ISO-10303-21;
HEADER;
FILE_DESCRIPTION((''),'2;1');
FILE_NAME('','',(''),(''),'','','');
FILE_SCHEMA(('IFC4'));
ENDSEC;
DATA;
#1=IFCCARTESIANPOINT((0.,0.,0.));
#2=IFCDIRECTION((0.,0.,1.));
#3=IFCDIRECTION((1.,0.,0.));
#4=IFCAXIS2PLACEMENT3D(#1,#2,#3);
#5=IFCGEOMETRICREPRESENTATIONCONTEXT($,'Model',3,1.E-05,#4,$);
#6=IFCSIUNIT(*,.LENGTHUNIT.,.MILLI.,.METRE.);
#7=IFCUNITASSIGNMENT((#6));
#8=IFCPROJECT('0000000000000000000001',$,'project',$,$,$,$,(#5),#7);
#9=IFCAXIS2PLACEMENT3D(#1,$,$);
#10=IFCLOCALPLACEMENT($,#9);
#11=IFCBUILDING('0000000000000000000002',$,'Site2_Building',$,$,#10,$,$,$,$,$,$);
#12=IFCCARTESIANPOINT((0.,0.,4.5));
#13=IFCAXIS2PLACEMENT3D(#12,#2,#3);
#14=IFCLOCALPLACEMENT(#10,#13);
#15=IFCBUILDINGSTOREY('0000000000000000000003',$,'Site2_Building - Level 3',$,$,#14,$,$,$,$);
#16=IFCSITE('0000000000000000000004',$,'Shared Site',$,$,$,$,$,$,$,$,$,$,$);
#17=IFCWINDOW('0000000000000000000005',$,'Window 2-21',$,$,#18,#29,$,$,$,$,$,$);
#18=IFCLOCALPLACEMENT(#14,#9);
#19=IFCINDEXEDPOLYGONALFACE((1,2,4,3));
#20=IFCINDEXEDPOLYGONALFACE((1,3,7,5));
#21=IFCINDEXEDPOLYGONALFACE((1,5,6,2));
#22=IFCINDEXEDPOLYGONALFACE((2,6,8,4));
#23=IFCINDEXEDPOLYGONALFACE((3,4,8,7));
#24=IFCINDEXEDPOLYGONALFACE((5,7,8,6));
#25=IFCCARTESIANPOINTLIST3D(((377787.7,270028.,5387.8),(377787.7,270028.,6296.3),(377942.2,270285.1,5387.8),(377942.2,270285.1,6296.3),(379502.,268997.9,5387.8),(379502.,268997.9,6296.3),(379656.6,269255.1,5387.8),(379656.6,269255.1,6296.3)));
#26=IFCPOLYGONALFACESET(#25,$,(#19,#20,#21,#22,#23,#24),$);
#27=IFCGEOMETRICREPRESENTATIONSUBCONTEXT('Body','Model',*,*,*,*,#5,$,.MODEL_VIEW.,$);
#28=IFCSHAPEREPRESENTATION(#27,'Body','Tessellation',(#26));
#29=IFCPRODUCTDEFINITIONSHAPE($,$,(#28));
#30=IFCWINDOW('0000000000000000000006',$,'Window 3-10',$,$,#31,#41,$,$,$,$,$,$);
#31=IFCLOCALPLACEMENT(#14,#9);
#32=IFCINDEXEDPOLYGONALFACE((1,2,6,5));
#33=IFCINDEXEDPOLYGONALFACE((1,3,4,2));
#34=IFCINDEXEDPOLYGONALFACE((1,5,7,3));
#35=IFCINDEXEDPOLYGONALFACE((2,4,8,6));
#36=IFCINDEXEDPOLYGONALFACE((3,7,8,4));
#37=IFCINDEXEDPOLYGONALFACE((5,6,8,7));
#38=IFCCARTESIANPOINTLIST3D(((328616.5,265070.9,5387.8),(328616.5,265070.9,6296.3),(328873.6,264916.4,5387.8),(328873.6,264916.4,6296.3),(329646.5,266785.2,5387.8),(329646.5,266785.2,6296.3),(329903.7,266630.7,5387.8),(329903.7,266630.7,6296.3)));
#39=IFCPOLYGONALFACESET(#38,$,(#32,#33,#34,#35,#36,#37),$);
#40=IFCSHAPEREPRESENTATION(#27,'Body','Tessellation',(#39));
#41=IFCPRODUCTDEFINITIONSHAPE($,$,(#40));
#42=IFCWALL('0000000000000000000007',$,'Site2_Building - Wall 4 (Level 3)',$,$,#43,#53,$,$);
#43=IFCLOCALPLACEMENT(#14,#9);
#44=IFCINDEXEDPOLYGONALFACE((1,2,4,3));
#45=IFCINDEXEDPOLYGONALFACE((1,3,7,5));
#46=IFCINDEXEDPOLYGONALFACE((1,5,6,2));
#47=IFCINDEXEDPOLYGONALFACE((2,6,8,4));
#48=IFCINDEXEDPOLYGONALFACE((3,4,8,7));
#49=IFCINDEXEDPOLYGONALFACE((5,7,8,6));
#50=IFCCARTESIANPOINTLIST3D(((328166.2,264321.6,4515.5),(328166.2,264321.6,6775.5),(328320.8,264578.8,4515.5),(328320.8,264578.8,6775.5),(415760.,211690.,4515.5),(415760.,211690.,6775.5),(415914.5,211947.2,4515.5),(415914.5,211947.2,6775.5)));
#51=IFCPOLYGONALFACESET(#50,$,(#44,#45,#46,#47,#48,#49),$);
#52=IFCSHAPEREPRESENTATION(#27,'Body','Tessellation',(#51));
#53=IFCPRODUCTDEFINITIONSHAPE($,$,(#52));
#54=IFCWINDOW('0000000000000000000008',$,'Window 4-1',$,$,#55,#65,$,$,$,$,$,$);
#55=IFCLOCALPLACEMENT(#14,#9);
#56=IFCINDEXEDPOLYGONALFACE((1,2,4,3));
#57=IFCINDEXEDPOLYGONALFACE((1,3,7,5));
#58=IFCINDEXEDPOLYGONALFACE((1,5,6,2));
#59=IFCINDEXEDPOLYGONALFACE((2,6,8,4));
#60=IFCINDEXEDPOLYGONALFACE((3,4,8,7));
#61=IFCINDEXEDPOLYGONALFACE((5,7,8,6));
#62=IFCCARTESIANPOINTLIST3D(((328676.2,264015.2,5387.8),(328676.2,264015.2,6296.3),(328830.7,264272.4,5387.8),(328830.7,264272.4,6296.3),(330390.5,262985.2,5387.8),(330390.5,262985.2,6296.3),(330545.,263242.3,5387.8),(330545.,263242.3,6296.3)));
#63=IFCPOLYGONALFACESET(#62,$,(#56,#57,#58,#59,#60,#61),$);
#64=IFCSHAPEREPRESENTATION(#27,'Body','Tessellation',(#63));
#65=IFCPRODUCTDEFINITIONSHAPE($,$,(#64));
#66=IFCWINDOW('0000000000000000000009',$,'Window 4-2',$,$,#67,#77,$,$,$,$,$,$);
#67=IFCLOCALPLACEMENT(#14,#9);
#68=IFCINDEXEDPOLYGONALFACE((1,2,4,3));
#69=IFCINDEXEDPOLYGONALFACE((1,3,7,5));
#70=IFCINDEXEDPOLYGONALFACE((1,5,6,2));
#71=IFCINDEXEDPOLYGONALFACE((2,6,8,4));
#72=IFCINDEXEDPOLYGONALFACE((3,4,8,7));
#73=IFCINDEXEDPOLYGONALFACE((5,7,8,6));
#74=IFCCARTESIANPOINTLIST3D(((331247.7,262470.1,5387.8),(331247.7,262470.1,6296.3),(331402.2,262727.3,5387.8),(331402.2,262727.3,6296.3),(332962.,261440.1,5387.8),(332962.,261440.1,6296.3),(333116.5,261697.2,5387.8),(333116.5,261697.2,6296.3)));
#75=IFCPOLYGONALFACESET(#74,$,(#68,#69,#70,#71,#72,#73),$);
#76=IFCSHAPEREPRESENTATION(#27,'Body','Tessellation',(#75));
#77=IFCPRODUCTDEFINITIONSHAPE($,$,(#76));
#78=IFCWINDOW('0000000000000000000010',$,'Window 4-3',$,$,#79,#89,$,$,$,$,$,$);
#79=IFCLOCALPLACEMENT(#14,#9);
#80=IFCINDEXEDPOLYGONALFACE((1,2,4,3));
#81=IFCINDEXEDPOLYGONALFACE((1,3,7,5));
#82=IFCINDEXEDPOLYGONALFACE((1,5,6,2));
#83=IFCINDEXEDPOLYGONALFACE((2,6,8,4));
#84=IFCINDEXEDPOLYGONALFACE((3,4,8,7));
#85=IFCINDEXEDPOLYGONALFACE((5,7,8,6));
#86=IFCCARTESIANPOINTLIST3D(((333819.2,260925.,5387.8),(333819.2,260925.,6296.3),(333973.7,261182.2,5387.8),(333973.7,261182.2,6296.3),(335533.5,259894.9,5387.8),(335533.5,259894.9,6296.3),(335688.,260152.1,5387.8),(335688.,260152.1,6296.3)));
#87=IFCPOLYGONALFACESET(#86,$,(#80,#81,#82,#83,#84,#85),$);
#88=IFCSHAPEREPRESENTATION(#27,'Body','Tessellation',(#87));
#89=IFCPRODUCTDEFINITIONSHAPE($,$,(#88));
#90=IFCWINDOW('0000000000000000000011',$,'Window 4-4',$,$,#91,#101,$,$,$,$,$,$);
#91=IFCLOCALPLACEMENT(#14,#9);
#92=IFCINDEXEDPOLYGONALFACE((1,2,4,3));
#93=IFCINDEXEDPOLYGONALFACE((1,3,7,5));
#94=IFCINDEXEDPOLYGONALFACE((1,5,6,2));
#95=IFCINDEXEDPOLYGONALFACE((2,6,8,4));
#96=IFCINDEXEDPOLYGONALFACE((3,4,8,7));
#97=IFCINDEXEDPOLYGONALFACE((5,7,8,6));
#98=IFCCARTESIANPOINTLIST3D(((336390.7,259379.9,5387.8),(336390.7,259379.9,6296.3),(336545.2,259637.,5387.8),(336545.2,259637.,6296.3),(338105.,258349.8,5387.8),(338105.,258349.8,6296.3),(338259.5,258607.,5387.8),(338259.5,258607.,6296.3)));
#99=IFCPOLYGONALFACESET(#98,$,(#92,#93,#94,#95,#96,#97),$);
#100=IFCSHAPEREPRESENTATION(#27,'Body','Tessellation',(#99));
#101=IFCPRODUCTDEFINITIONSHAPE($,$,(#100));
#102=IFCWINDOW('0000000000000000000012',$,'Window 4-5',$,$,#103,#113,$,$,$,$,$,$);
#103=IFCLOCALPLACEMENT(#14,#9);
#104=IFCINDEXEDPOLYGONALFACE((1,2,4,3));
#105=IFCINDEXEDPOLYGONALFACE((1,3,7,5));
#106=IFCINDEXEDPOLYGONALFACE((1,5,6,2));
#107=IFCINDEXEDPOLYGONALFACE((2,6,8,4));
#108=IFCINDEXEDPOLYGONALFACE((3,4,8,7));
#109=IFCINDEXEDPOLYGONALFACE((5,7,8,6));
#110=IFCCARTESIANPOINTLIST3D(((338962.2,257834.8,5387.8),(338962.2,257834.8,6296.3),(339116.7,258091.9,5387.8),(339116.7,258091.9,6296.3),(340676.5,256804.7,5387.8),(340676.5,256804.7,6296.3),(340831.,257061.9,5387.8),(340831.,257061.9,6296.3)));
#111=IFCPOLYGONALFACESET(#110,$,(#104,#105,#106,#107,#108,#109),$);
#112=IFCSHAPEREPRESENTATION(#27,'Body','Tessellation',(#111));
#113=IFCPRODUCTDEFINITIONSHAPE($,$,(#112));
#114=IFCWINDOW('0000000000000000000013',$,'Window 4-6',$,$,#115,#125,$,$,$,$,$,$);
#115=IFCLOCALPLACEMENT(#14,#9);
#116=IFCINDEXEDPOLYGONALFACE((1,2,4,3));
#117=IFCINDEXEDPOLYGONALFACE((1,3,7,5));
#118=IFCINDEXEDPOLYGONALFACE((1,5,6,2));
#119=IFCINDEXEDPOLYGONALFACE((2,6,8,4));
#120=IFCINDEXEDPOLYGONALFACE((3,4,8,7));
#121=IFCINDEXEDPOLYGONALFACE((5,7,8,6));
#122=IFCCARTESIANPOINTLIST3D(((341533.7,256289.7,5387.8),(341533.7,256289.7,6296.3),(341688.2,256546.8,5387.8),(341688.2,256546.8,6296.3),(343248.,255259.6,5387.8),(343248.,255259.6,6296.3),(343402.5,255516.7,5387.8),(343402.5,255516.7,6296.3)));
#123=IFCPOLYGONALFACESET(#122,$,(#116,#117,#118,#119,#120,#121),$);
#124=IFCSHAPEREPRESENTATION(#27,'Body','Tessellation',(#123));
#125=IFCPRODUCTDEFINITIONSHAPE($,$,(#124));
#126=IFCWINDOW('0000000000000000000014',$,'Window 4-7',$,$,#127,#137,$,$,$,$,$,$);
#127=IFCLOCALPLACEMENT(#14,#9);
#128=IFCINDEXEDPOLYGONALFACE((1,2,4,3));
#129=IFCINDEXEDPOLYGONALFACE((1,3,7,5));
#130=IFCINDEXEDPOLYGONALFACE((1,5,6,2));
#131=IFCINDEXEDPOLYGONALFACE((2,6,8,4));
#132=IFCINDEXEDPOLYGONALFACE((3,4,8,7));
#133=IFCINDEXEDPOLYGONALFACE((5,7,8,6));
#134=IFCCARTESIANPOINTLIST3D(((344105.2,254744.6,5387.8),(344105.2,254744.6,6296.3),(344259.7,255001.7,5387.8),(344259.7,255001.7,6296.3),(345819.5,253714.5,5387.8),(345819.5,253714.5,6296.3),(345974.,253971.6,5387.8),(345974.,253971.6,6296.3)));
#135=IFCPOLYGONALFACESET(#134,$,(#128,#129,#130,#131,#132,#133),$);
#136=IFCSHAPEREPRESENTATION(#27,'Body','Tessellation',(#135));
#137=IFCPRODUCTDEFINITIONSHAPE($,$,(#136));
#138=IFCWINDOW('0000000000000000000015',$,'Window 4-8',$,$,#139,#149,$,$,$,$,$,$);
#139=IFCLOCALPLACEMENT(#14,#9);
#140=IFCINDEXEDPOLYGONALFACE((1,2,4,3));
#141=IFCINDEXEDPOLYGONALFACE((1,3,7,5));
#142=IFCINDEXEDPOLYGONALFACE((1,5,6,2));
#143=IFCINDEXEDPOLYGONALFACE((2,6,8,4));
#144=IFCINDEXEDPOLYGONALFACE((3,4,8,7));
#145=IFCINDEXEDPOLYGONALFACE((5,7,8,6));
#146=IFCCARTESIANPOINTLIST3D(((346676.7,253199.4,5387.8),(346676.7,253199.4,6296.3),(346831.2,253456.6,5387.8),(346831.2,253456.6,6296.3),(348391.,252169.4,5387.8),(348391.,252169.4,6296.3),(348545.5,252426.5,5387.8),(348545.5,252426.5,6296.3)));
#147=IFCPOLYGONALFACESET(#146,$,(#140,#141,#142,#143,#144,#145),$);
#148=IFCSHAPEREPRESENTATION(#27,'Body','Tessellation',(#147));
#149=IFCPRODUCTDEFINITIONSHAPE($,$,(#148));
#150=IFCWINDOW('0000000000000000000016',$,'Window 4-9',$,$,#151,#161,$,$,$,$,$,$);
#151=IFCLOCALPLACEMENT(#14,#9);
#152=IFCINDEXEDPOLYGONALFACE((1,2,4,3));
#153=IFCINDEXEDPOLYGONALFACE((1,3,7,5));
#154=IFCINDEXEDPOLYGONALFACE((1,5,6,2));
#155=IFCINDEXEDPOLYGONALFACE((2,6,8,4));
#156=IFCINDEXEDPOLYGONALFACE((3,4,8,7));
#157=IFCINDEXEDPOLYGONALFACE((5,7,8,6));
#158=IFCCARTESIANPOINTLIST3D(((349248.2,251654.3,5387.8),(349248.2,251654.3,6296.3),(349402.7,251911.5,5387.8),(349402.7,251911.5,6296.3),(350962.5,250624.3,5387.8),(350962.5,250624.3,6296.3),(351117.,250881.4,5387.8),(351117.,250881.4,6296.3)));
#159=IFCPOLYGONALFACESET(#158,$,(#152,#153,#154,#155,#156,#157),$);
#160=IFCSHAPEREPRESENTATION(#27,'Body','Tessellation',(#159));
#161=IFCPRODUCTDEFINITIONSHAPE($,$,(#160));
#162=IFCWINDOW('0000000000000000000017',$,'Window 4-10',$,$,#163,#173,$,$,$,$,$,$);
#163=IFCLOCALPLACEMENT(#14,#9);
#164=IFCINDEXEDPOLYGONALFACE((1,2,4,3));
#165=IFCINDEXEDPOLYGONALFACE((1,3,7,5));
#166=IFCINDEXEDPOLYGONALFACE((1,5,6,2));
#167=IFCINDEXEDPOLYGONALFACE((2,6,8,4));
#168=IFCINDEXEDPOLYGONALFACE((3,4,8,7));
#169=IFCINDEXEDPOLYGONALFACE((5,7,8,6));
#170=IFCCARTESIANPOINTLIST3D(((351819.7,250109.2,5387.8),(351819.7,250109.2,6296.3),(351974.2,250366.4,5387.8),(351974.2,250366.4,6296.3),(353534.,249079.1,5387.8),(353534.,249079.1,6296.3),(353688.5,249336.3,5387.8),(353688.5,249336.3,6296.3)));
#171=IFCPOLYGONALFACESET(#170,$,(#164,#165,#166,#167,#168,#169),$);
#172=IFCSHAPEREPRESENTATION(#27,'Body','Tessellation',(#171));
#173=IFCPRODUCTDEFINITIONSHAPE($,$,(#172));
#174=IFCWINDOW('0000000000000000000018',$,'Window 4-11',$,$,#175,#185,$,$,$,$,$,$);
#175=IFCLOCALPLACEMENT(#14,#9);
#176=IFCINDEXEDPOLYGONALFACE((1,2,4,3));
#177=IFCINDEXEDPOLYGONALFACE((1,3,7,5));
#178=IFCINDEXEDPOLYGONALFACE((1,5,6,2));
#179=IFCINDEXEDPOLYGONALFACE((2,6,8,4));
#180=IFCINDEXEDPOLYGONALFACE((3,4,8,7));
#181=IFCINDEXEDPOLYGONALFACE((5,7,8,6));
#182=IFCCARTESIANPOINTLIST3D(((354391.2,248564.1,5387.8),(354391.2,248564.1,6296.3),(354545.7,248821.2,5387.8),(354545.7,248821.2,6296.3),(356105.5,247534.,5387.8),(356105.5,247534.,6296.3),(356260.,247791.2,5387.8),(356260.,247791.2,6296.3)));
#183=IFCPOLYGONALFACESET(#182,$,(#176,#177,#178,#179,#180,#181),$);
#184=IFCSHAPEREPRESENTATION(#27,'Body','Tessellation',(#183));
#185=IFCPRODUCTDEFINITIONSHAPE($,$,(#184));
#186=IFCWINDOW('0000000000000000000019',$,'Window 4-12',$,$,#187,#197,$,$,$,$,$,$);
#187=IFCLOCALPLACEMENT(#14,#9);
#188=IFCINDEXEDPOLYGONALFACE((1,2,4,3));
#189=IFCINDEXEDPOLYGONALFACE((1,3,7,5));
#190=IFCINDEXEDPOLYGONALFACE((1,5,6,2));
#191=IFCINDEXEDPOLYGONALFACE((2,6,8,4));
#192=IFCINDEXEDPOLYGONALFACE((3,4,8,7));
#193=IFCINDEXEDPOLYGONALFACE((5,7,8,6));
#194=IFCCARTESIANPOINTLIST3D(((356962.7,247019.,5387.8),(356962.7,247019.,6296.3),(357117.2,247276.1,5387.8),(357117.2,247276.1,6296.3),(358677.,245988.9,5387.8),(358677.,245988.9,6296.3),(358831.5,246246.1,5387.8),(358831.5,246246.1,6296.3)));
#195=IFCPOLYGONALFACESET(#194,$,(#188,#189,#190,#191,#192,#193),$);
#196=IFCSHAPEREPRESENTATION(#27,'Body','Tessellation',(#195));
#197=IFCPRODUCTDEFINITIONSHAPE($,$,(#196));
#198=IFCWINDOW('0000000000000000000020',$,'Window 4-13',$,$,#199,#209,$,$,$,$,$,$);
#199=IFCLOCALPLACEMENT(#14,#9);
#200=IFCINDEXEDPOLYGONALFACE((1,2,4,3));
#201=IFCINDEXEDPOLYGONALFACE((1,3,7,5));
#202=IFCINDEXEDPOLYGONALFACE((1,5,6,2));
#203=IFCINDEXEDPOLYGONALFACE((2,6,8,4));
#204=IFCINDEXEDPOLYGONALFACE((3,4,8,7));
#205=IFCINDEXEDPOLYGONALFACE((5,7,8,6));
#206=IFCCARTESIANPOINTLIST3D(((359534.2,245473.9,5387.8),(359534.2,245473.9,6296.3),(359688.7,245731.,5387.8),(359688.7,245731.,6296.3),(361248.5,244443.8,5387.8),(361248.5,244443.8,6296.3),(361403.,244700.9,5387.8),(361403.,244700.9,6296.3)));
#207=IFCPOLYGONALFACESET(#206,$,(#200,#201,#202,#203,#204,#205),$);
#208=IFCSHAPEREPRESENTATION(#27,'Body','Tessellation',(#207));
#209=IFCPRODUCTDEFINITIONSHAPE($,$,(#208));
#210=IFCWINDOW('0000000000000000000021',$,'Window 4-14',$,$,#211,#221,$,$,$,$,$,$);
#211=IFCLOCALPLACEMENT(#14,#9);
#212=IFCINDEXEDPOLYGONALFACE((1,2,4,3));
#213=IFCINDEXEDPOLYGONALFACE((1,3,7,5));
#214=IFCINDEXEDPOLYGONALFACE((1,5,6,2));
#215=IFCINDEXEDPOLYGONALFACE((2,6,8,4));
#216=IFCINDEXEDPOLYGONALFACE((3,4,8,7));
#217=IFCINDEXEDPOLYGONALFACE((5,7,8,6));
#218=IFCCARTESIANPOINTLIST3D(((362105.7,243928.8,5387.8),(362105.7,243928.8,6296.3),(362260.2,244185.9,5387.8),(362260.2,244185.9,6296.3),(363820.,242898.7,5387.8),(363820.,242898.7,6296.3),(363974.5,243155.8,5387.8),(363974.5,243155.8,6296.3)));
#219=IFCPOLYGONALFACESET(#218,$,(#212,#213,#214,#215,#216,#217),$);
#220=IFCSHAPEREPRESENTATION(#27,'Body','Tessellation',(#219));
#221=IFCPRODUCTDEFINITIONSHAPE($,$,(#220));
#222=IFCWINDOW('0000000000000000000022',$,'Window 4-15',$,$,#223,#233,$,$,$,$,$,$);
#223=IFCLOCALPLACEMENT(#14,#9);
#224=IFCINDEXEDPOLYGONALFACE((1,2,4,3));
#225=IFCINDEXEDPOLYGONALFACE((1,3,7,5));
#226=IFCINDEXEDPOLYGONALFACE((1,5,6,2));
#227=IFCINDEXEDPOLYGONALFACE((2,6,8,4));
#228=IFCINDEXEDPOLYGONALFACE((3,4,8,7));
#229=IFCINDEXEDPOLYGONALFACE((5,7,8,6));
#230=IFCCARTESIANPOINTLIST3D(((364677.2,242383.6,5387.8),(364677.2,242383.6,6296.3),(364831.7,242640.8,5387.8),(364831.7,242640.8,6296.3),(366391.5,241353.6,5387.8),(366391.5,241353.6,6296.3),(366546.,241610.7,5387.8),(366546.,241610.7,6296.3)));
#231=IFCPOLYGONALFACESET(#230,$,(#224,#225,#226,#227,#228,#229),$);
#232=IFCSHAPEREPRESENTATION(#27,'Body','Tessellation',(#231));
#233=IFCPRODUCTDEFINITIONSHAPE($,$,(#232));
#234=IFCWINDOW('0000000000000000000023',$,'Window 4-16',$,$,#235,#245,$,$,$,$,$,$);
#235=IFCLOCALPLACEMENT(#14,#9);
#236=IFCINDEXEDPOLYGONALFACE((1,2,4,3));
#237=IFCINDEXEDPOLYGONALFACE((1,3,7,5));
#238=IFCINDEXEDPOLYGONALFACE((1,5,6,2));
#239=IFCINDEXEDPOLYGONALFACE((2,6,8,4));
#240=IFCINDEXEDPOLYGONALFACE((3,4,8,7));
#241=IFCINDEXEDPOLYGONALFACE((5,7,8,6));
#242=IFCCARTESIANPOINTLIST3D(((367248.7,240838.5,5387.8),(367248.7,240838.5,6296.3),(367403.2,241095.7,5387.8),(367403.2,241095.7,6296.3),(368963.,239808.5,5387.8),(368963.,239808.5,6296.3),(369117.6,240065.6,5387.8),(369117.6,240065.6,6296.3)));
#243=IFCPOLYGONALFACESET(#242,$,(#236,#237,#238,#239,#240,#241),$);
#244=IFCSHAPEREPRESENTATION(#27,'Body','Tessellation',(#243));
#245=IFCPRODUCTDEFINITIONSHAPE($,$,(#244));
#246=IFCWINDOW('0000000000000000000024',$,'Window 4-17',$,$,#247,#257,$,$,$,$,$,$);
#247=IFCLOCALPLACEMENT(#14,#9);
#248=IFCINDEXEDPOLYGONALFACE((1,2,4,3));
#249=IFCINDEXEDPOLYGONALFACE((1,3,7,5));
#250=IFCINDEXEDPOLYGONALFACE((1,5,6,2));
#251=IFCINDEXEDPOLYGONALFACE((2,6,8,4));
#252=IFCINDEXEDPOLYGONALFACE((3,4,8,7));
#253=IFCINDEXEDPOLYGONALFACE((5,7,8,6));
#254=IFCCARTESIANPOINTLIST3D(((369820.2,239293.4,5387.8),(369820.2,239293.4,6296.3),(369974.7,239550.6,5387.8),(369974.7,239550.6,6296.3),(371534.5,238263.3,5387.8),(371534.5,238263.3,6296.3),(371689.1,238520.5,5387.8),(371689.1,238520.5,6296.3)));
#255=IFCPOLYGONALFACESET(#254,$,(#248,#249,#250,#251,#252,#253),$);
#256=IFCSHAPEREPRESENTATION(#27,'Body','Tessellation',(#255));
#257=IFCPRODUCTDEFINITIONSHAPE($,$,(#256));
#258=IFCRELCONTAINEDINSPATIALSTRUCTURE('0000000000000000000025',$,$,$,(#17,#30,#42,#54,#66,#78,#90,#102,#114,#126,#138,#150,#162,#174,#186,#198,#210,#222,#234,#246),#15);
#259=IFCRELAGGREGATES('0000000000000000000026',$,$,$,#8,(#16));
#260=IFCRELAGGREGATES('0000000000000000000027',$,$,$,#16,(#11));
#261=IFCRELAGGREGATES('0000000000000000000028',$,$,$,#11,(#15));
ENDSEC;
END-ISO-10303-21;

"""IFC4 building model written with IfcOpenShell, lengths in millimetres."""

from ifc_helpers import new_model, si_unit, frame, origin, origin_with_axes, place, context, subcontext, project, spatial, indexed_curve, outline, extrude, element, save


model = new_model("IFC4")

# Units and contexts
model_context = context("Model", 3, precision=1e-05, world=origin_with_axes())
body_context = subcontext(model_context, "Body", "Model", "MODEL_VIEW")
ifc_project = project(units=[si_unit("LENGTHUNIT", "METRE", prefix="MILLI")], contexts=[model_context])

# Site, building, storey
site = spatial("IfcSite", under=ifc_project, Name="Shared Site")
building_placement = place(None, origin())
building = spatial("IfcBuilding", under=site, at=building_placement, Name="Site2_Building")
storey_placement = place(building_placement, frame((0.0, 0.0, 4.5), z_axis=(0.0, 0.0, 1.0), x_axis=(1.0, 0.0, 0.0)))
storey = spatial("IfcBuildingStorey", under=building, at=storey_placement, Name="Site2_Building - Level 3")

# Windows
for number, where, z_axis, x_axis, name in (
    (1, (379656.6, 269255.1, 5387.8), (0.0, 0.0, 1.0), (-0.857167, 0.515038, 0.0), "Window 2-21"),
    (2, (329646.5, 266785.2, 5387.8), (0.0, 0.0, 1.0), (-0.515038, -0.857167, 0.0), "Window 3-10"),
):
    element("IfcWindow", number, at=place(storey_placement, frame(where, z_axis=z_axis, x_axis=x_axis)), inside=storey, Name=name, context=body_context, shape_type="SweptSolid", body=[
        extrude(outline(indexed_curve([(0.0, 0.0), (0.0, 300.0), (2000.0, 300.0), (2000.0, 0.0), (0.0, 0.0)], self_intersect=False)), origin_with_axes(), (0.0, 0.0, 1.0), 908.6),
    ])

# Wall
wall_placement = place(storey_placement, frame((328166.2, 264321.6, 4515.5), z_axis=(0.0, 0.0, 1.0), x_axis=(0.857167, -0.515038, 0.0)))
element("IfcWall", 3, at=wall_placement, inside=storey, Name="Site2_Building - Wall 4 (Level 3)", context=body_context, shape_type="SweptSolid", body=[
    extrude(outline(indexed_curve([(0.0, 0.0), (0.0, 300.0), (102189.8, 300.0), (102189.8, 0.0), (0.0, 0.0)], self_intersect=False)), origin_with_axes(), (0.0, 0.0, 1.0), 2260.0),
])

# Windows
for number, where, z_axis, x_axis, name in (
    (4, (328676.2, 264015.2, 5387.8), (0.0, 0.0, 1.0), (0.857167, -0.515038, 0.0), "Window 4-1"),
    (5, (331247.7, 262470.1, 5387.8), (0.0, 0.0, 1.0), (0.857167, -0.515038, 0.0), "Window 4-2"),
    (6, (333819.2, 260925.0, 5387.8), (0.0, 0.0, 1.0), (0.857167, -0.515038, 0.0), "Window 4-3"),
    (7, (336390.7, 259379.9, 5387.8), (0.0, 0.0, 1.0), (0.857167, -0.515038, 0.0), "Window 4-4"),
    (8, (338962.2, 257834.8, 5387.8), (0.0, 0.0, 1.0), (0.857167, -0.515038, 0.0), "Window 4-5"),
    (9, (341533.7, 256289.7, 5387.8), (0.0, 0.0, 1.0), (0.857167, -0.515038, 0.0), "Window 4-6"),
    (10, (344105.2, 254744.6, 5387.8), (0.0, 0.0, 1.0), (0.857167, -0.515038, 0.0), "Window 4-7"),
    (11, (346676.7, 253199.4, 5387.8), (0.0, 0.0, 1.0), (0.857167, -0.515038, 0.0), "Window 4-8"),
    (12, (349248.2, 251654.3, 5387.8), (0.0, 0.0, 1.0), (0.857167, -0.515038, 0.0), "Window 4-9"),
    (13, (351819.7, 250109.2, 5387.8), (0.0, 0.0, 1.0), (0.857167, -0.515038, 0.0), "Window 4-10"),
    (14, (354391.2, 248564.1, 5387.8), (0.0, 0.0, 1.0), (0.857167, -0.515038, 0.0), "Window 4-11"),
    (15, (356962.7, 247019.0, 5387.8), (0.0, 0.0, 1.0), (0.857167, -0.515038, 0.0), "Window 4-12"),
    (16, (359534.2, 245473.9, 5387.8), (0.0, 0.0, 1.0), (0.857167, -0.515038, 0.0), "Window 4-13"),
    (17, (362105.7, 243928.8, 5387.8), (0.0, 0.0, 1.0), (0.857167, -0.515038, 0.0), "Window 4-14"),
    (18, (364677.2, 242383.6, 5387.8), (0.0, 0.0, 1.0), (0.857167, -0.515038, 0.0), "Window 4-15"),
    (19, (367248.7, 240838.5, 5387.8), (0.0, 0.0, 1.0), (0.857167, -0.515038, 0.0), "Window 4-16"),
    (20, (369820.2, 239293.4, 5387.8), (0.0, 0.0, 1.0), (0.857167, -0.515038, 0.0), "Window 4-17"),
):
    element("IfcWindow", number, at=place(storey_placement, frame(where, z_axis=z_axis, x_axis=x_axis)), inside=storey, Name=name, context=body_context, shape_type="SweptSolid", body=[
        extrude(outline(indexed_curve([(0.0, 0.0), (0.0, 300.0), (2000.0, 300.0), (2000.0, 0.0), (0.0, 0.0)], self_intersect=False)), origin_with_axes(), (0.0, 0.0, 1.0), 908.6),
    ])

save(model, "model.ifc")
